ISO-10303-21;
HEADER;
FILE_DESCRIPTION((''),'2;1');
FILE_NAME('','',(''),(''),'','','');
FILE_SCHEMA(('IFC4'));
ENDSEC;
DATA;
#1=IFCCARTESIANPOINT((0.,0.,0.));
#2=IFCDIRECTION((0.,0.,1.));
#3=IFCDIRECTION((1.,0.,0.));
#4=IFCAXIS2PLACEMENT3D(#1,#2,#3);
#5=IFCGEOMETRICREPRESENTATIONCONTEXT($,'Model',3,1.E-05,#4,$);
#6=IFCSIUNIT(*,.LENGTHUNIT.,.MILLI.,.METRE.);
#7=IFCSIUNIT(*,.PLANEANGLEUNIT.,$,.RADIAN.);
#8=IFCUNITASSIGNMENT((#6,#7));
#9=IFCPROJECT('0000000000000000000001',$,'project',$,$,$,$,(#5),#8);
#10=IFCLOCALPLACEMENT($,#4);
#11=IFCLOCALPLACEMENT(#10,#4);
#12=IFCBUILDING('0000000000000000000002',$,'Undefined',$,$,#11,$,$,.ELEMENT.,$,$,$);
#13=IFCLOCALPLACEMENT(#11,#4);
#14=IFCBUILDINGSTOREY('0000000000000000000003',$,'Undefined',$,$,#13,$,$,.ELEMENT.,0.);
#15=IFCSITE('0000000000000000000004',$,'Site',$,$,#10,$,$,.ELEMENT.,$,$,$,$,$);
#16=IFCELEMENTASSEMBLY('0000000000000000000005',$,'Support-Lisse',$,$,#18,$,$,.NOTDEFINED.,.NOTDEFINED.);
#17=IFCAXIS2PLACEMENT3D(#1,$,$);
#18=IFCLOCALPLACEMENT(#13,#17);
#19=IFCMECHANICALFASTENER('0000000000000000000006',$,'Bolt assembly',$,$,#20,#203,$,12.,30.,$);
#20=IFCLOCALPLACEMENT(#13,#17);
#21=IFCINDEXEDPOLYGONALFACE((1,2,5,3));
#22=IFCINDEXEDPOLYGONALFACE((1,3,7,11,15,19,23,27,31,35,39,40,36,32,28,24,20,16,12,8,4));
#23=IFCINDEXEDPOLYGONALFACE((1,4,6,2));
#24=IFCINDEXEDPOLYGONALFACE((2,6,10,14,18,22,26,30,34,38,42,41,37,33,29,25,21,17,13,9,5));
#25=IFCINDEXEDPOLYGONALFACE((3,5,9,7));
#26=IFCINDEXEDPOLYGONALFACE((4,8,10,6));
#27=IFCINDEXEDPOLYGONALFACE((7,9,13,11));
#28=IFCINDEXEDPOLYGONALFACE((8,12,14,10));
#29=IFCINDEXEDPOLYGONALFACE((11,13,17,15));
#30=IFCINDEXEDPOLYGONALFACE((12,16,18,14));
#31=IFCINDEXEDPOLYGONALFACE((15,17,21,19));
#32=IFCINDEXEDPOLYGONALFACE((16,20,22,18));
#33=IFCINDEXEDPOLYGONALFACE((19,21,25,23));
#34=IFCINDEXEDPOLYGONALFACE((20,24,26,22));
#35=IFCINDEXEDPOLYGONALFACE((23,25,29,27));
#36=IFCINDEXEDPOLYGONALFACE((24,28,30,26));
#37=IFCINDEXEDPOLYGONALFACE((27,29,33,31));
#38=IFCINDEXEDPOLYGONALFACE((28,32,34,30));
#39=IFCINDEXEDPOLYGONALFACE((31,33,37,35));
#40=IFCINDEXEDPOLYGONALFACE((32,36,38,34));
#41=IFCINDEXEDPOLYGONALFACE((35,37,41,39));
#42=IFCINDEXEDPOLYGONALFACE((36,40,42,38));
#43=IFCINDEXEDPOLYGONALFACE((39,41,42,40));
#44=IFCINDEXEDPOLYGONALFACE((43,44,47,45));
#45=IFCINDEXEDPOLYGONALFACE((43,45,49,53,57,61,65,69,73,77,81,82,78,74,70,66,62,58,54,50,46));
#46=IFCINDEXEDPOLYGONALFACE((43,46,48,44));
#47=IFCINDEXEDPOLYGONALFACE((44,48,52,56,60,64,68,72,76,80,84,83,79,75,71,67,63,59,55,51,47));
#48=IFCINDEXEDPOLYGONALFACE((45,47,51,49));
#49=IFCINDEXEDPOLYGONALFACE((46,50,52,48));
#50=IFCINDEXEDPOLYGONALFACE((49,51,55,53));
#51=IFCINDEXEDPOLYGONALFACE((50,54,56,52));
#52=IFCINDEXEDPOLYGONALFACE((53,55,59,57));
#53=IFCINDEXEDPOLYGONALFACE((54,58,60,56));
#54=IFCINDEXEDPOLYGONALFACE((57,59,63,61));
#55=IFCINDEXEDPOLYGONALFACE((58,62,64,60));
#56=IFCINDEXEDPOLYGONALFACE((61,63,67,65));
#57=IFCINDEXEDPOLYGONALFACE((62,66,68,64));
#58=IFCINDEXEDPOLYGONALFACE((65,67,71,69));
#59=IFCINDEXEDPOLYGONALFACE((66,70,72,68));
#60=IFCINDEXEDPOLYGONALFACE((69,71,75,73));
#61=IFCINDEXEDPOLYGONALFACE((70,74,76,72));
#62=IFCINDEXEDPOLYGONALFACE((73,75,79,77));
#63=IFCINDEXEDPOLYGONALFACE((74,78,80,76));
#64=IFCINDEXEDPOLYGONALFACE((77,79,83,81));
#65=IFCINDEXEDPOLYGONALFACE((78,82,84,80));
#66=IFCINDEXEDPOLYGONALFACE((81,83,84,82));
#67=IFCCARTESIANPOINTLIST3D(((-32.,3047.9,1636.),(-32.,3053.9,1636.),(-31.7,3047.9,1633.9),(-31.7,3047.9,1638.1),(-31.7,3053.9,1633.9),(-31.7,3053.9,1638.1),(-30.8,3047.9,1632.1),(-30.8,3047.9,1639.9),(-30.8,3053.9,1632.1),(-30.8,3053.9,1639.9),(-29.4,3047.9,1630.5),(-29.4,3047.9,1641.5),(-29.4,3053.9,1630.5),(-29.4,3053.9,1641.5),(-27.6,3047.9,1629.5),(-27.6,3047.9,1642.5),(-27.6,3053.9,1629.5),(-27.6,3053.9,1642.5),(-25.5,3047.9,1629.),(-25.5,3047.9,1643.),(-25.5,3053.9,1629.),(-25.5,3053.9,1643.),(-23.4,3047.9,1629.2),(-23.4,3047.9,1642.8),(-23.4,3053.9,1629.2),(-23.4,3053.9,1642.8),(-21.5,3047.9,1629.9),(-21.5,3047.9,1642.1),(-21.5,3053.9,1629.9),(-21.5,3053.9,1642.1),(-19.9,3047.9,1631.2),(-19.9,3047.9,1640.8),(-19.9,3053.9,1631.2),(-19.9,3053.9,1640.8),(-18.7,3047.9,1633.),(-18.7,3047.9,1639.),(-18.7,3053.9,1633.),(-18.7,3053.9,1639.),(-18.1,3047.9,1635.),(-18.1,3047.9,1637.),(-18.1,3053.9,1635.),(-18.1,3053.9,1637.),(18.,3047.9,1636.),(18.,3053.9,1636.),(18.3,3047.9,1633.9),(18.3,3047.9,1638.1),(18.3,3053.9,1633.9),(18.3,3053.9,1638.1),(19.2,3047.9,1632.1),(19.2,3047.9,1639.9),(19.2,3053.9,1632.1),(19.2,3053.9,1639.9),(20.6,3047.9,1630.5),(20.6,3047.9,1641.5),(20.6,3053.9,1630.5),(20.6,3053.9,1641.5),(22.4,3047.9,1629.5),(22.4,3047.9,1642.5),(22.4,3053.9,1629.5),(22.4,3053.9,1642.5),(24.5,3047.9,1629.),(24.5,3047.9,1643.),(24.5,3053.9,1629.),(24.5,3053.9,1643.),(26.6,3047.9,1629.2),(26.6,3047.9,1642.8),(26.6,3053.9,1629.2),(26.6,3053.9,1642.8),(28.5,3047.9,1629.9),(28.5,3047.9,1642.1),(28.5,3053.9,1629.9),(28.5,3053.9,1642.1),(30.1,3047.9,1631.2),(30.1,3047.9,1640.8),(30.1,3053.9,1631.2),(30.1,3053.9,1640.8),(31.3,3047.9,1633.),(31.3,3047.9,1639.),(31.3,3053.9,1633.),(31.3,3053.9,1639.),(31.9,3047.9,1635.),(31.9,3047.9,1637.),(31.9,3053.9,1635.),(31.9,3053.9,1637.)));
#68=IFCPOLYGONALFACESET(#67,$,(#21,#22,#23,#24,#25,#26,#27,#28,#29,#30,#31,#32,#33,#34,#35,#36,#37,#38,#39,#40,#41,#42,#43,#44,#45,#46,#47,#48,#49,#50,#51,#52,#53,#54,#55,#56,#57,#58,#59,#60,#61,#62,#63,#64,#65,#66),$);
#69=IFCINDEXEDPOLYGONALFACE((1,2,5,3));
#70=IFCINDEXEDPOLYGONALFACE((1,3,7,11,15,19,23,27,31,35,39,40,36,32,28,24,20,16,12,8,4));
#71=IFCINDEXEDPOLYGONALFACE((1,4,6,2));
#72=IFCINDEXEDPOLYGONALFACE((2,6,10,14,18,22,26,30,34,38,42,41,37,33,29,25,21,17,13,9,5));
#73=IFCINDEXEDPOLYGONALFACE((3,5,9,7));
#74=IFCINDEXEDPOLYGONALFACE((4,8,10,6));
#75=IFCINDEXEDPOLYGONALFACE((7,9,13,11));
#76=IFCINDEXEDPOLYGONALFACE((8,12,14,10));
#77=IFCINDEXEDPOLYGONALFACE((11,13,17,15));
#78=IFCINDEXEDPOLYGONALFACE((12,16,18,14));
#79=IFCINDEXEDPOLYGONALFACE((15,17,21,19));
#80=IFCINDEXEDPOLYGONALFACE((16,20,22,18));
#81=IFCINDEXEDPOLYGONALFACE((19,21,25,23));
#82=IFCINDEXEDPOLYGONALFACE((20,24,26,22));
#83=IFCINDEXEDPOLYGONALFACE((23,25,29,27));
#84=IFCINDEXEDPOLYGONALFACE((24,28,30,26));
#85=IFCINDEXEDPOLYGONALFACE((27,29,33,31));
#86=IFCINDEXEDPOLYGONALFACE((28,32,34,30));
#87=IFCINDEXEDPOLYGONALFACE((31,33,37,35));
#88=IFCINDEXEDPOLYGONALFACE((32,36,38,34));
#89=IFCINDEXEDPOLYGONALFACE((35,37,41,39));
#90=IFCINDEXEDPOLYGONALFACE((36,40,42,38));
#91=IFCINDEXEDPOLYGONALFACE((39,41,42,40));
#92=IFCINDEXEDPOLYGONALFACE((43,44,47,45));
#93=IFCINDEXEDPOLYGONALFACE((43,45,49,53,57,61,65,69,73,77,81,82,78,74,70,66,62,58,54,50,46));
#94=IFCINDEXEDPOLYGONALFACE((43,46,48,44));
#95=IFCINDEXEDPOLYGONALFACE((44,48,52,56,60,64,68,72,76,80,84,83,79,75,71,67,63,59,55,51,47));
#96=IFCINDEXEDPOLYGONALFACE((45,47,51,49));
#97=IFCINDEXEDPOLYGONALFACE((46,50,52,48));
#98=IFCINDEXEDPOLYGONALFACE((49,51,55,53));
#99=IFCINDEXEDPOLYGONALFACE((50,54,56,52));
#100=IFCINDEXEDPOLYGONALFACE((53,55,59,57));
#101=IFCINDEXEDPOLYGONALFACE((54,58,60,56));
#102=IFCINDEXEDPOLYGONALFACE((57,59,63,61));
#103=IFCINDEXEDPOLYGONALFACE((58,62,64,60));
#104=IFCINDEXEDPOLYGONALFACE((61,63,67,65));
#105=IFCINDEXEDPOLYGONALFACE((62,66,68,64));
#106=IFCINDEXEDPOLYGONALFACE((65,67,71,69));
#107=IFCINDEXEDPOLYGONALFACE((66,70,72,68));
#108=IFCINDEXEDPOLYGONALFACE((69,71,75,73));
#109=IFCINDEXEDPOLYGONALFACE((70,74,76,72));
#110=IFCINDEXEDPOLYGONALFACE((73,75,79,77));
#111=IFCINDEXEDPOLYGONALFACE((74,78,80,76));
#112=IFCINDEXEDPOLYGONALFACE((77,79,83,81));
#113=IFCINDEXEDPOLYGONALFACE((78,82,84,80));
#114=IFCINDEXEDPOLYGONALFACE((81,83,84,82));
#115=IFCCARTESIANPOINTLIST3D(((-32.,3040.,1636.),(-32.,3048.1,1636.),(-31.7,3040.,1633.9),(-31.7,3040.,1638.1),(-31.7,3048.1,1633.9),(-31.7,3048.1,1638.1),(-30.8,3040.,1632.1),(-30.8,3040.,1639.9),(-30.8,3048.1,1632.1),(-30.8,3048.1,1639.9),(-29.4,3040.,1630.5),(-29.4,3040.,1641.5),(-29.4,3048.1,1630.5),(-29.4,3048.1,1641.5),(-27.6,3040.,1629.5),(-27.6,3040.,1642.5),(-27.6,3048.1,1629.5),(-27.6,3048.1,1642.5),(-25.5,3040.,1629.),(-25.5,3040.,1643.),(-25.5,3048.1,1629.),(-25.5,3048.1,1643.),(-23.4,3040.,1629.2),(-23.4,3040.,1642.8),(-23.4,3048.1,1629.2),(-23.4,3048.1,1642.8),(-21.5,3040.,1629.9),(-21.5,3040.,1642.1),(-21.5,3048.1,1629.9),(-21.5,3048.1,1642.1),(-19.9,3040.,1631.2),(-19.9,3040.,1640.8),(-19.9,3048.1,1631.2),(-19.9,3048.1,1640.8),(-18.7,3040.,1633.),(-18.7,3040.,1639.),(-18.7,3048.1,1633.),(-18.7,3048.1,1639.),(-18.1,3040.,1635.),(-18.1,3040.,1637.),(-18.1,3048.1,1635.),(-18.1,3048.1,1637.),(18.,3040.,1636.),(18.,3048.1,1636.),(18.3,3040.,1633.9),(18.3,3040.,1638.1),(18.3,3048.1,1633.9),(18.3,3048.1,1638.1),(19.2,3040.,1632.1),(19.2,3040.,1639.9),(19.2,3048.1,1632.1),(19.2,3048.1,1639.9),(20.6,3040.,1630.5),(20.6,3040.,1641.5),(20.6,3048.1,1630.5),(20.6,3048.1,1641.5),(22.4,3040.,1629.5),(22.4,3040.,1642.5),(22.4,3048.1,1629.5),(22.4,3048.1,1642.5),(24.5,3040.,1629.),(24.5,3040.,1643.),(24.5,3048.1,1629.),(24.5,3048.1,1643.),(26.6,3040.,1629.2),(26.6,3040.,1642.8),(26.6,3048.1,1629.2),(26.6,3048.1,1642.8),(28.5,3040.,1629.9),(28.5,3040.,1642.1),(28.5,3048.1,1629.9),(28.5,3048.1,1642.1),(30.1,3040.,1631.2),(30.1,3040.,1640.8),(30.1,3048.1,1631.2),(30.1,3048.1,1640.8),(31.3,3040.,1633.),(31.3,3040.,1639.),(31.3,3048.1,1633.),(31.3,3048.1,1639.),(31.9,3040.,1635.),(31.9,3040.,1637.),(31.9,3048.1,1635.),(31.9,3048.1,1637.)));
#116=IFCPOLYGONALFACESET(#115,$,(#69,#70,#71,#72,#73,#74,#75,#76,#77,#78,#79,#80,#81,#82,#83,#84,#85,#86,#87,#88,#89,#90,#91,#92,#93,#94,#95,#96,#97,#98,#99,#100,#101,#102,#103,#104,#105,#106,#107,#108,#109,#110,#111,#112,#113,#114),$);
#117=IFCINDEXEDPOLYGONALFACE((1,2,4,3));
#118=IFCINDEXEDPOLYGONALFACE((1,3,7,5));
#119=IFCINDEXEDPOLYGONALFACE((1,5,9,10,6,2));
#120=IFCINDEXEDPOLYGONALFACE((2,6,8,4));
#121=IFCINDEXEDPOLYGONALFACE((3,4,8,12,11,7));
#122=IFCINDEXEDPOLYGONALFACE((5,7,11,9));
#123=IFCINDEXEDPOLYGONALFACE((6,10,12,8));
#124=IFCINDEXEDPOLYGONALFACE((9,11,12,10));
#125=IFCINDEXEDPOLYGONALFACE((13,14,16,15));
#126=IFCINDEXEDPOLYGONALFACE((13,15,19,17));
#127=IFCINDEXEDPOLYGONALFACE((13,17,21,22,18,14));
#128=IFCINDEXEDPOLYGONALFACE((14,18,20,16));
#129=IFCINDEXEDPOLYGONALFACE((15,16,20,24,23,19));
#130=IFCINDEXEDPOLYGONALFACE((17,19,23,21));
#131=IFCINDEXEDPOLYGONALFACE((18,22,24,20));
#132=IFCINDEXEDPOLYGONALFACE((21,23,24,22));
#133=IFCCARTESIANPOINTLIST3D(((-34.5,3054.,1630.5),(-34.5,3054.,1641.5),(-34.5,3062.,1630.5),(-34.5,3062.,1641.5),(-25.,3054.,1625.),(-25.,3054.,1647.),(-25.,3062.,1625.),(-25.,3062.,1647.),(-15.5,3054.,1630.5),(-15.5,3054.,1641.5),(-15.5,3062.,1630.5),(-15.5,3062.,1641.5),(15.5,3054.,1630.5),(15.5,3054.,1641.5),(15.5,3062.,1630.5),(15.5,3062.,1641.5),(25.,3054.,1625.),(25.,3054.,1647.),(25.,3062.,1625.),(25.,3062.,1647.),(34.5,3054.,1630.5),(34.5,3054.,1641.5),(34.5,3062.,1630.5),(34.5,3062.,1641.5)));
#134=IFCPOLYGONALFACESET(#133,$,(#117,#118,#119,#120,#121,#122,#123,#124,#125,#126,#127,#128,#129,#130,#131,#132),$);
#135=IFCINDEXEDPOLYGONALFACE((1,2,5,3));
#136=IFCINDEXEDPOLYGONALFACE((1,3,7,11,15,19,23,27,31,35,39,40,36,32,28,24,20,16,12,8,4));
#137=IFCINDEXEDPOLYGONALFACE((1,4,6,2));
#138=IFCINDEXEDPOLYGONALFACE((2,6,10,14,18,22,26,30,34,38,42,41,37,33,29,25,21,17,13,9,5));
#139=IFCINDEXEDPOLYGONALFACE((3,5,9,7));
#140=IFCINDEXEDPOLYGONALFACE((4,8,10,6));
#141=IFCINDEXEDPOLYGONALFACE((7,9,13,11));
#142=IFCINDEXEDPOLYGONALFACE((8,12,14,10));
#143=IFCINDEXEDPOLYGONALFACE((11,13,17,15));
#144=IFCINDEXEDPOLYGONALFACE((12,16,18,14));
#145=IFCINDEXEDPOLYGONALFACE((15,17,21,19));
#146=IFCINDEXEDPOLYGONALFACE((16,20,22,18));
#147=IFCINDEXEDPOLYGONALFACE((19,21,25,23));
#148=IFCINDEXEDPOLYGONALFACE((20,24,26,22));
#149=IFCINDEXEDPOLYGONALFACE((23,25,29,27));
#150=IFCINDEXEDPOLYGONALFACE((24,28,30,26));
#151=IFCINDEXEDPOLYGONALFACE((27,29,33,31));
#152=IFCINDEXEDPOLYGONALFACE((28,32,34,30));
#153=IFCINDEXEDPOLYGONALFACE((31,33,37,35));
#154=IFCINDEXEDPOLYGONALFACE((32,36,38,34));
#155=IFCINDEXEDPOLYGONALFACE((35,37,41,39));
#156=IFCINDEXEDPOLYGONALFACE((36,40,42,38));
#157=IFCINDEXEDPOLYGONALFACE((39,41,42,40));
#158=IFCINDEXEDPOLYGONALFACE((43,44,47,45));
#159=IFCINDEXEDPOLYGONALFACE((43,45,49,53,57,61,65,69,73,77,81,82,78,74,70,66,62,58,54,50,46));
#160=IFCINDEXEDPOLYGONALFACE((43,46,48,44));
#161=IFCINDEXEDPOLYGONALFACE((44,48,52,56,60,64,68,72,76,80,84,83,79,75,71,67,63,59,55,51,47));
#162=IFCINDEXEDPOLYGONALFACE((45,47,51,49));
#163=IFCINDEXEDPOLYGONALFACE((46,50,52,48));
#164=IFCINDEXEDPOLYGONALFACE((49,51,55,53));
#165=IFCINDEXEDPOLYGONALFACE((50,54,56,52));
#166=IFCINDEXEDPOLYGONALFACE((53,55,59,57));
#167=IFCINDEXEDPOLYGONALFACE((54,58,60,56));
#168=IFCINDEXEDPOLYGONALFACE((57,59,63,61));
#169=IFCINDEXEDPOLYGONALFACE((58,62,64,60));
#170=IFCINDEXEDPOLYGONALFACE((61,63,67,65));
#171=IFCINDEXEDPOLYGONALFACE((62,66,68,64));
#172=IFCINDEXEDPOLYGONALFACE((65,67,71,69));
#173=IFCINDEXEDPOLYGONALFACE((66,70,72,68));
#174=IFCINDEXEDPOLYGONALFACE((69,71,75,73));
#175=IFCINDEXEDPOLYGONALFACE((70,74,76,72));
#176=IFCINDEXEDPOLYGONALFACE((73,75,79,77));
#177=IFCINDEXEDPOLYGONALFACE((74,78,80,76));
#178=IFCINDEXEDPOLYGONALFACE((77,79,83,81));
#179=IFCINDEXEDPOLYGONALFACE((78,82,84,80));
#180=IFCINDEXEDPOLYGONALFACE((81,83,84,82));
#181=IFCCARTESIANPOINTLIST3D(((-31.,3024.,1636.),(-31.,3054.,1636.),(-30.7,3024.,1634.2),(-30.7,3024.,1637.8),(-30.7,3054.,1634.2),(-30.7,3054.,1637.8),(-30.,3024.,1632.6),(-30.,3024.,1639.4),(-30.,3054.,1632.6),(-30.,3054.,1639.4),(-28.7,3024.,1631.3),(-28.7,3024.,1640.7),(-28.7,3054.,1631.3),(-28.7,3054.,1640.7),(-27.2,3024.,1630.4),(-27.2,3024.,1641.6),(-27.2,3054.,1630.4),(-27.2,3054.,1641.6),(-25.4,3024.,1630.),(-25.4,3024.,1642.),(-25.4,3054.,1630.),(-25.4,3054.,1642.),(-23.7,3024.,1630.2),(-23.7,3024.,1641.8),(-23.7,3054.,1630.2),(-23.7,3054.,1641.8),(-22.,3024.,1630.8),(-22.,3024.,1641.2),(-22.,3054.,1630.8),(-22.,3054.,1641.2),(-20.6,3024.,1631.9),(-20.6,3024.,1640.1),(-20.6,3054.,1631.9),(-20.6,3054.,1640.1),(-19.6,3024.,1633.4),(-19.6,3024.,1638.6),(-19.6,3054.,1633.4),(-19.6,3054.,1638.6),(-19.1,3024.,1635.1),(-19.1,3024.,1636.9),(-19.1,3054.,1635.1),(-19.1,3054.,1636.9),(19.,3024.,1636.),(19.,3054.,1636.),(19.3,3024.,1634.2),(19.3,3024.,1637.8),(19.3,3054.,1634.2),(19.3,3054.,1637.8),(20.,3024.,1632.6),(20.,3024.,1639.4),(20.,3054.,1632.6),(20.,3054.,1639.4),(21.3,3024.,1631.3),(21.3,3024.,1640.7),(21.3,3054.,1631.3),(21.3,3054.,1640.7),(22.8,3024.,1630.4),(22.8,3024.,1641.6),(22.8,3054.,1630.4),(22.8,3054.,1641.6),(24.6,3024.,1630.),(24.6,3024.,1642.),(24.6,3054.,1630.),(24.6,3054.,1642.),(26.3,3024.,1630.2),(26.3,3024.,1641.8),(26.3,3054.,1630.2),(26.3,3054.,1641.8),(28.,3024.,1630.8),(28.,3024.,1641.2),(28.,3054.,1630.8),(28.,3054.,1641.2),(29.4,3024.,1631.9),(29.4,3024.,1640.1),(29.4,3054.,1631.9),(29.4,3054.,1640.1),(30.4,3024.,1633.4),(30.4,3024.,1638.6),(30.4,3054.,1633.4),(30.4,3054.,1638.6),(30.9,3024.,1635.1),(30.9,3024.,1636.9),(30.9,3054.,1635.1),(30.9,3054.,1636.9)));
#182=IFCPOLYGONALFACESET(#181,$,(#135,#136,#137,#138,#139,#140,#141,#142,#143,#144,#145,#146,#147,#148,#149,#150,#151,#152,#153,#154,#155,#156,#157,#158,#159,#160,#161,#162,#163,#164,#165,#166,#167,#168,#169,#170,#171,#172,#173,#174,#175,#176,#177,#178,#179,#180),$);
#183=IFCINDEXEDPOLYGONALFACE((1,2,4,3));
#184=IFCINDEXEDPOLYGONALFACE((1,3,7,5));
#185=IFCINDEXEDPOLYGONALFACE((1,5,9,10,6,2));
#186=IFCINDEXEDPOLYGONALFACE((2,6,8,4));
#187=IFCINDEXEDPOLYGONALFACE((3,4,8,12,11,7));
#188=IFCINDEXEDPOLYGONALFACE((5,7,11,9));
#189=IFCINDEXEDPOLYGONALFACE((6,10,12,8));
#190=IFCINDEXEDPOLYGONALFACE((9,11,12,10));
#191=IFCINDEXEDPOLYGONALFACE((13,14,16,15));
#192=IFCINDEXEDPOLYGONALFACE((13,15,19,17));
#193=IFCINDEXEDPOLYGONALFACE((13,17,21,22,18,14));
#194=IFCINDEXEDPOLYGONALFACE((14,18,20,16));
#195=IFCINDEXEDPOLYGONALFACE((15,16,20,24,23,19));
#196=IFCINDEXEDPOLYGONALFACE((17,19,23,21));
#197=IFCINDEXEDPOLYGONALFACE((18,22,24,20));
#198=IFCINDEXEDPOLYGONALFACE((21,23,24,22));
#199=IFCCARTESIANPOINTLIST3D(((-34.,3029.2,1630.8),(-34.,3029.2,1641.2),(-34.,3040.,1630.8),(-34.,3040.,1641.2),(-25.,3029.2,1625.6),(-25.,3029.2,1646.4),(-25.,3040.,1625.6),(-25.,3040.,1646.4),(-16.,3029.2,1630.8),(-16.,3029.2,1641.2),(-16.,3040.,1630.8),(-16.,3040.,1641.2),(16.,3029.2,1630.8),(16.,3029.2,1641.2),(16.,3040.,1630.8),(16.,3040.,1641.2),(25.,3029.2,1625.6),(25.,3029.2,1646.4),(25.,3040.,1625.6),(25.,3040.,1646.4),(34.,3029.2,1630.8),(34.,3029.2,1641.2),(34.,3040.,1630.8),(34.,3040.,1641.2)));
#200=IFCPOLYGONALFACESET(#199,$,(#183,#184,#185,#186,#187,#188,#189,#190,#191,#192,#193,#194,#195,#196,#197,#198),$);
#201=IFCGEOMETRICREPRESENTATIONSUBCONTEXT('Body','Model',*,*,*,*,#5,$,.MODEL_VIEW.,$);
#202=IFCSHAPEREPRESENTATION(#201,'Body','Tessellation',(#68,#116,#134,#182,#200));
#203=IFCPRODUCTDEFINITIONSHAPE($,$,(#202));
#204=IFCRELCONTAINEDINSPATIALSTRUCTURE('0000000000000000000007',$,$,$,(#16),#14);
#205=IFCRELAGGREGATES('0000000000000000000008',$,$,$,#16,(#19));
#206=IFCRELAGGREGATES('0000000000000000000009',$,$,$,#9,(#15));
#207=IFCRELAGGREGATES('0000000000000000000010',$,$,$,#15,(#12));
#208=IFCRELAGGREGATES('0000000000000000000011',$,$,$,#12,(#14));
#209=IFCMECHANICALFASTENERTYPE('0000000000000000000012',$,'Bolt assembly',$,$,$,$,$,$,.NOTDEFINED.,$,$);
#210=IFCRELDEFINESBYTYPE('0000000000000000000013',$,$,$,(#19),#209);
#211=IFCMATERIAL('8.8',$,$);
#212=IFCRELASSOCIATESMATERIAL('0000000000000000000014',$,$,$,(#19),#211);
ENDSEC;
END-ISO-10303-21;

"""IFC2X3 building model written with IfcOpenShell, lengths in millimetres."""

from ifc_helpers import new_model, si_unit, frame, origin_with_axes, origin_2d_with_axis, place, context, subcontext, project, spatial, polyline, circle, outline, extrude, source, transform, mapped, material, type_object, element, aggregate, save


model = new_model("IFC2X3")

# Units and contexts
model_context = context("Model", 3, precision=1e-05, world=origin_with_axes())
body_context = subcontext(model_context, "Body", "Model", "MODEL_VIEW")
ifc_project = project(units=[si_unit("LENGTHUNIT", "METRE", prefix="MILLI"), si_unit("PLANEANGLEUNIT", "RADIAN")], contexts=[model_context])

# Site, building, storey
site_placement = place(None, origin_with_axes())
site = spatial("IfcSite", under=ifc_project, at=site_placement, Name="Site", CompositionType="ELEMENT")
building_placement = place(site_placement, origin_with_axes())
building = spatial("IfcBuilding", under=site, at=building_placement, Name="Undefined", CompositionType="ELEMENT")
storey_placement = place(building_placement, origin_with_axes())
storey = spatial("IfcBuildingStorey", under=building, at=storey_placement, Name="Undefined", CompositionType="ELEMENT", Elevation=0.0)

# Shared definitions
mechanical_fastener_type = type_object("IfcMechanicalFastenerType", Name="Bolt assembly")
ifc_material_1 = material(Name="8.8")

# Shared definitions
shared_shape_1 = source(origin_with_axes(), body_context, "Body", "SweptSolid", [
    extrude(circle(Radius=7.0, at=origin_2d_with_axis()), frame((0.0, -5.9, 0.0), z_axis=(0.0, 1.0, 0.0), x_axis=(1.0, 0.0, 0.0)), (0.0, 0.0, 1.0), 6.0),
    extrude(circle(Radius=7.0, at=origin_2d_with_axis()), frame((0.0, -0.1, 0.0), z_axis=(0.0, 1.0, 0.0), x_axis=(1.0, 0.0, 0.0)), (0.0, 0.0, 1.0), 8.1),
    extrude(outline(polyline([(9.5, -5.5), (9.5, 5.5), (0.0, 11.0), (-9.5, 5.5), (-9.5, -5.5), (0.0, -11.0), (9.5, -5.5)])), frame((0.0, -14.0, 0.0), z_axis=(0.0, 1.0, 0.0), x_axis=(1.0, 0.0, 0.0)), (0.0, 0.0, 1.0), 8.0),
    extrude(circle(Radius=6.0, at=origin_2d_with_axis()), frame((0.0, -6.0, 0.0), z_axis=(0.0, 1.0, 0.0), x_axis=(1.0, 0.0, 0.0)), (0.0, 0.0, 1.0), 30.0),
    extrude(outline(polyline([(9.0, -5.2), (9.0, 5.2), (0.0, 10.4), (-9.0, 5.2), (-9.0, -5.2), (0.0, -10.4), (9.0, -5.2)])), frame((0.0, 8.0, 0.0), z_axis=(0.0, 1.0, 0.0), x_axis=(1.0, 0.0, 0.0)), (0.0, 0.0, 1.0), 10.8),
])

# Element assembly, mechanical fastener
assembly_1_placement = place(storey_placement, origin_with_axes())
assembly_1 = element("IfcElementAssembly", 1, at=assembly_1_placement, inside=storey, Name="Support-Lisse", AssemblyPlace="NOTDEFINED", PredefinedType="NOTDEFINED")
mechanical_fastener_1_placement = place(assembly_1_placement, frame((25.0, 3048.0, 1636.0), z_axis=(0.0, 0.0, 1.0), x_axis=(-1.0, 0.0, 0.0)))
mechanical_fastener_1 = element("IfcMechanicalFastener", 2, at=mechanical_fastener_1_placement, type_object=mechanical_fastener_type, material=ifc_material_1, Name="Bolt assembly", NominalDiameter=12.0, NominalLength=30.0, context=body_context, shape_type="MappedRepresentation", body=[
    mapped(shared_shape_1, transform((0.0, 0.0, 0.0))),
    mapped(shared_shape_1, transform((50.0, 0.0, 0.0))),
])
aggregate(assembly_1, [mechanical_fastener_1])

save(model, "model.ifc")
